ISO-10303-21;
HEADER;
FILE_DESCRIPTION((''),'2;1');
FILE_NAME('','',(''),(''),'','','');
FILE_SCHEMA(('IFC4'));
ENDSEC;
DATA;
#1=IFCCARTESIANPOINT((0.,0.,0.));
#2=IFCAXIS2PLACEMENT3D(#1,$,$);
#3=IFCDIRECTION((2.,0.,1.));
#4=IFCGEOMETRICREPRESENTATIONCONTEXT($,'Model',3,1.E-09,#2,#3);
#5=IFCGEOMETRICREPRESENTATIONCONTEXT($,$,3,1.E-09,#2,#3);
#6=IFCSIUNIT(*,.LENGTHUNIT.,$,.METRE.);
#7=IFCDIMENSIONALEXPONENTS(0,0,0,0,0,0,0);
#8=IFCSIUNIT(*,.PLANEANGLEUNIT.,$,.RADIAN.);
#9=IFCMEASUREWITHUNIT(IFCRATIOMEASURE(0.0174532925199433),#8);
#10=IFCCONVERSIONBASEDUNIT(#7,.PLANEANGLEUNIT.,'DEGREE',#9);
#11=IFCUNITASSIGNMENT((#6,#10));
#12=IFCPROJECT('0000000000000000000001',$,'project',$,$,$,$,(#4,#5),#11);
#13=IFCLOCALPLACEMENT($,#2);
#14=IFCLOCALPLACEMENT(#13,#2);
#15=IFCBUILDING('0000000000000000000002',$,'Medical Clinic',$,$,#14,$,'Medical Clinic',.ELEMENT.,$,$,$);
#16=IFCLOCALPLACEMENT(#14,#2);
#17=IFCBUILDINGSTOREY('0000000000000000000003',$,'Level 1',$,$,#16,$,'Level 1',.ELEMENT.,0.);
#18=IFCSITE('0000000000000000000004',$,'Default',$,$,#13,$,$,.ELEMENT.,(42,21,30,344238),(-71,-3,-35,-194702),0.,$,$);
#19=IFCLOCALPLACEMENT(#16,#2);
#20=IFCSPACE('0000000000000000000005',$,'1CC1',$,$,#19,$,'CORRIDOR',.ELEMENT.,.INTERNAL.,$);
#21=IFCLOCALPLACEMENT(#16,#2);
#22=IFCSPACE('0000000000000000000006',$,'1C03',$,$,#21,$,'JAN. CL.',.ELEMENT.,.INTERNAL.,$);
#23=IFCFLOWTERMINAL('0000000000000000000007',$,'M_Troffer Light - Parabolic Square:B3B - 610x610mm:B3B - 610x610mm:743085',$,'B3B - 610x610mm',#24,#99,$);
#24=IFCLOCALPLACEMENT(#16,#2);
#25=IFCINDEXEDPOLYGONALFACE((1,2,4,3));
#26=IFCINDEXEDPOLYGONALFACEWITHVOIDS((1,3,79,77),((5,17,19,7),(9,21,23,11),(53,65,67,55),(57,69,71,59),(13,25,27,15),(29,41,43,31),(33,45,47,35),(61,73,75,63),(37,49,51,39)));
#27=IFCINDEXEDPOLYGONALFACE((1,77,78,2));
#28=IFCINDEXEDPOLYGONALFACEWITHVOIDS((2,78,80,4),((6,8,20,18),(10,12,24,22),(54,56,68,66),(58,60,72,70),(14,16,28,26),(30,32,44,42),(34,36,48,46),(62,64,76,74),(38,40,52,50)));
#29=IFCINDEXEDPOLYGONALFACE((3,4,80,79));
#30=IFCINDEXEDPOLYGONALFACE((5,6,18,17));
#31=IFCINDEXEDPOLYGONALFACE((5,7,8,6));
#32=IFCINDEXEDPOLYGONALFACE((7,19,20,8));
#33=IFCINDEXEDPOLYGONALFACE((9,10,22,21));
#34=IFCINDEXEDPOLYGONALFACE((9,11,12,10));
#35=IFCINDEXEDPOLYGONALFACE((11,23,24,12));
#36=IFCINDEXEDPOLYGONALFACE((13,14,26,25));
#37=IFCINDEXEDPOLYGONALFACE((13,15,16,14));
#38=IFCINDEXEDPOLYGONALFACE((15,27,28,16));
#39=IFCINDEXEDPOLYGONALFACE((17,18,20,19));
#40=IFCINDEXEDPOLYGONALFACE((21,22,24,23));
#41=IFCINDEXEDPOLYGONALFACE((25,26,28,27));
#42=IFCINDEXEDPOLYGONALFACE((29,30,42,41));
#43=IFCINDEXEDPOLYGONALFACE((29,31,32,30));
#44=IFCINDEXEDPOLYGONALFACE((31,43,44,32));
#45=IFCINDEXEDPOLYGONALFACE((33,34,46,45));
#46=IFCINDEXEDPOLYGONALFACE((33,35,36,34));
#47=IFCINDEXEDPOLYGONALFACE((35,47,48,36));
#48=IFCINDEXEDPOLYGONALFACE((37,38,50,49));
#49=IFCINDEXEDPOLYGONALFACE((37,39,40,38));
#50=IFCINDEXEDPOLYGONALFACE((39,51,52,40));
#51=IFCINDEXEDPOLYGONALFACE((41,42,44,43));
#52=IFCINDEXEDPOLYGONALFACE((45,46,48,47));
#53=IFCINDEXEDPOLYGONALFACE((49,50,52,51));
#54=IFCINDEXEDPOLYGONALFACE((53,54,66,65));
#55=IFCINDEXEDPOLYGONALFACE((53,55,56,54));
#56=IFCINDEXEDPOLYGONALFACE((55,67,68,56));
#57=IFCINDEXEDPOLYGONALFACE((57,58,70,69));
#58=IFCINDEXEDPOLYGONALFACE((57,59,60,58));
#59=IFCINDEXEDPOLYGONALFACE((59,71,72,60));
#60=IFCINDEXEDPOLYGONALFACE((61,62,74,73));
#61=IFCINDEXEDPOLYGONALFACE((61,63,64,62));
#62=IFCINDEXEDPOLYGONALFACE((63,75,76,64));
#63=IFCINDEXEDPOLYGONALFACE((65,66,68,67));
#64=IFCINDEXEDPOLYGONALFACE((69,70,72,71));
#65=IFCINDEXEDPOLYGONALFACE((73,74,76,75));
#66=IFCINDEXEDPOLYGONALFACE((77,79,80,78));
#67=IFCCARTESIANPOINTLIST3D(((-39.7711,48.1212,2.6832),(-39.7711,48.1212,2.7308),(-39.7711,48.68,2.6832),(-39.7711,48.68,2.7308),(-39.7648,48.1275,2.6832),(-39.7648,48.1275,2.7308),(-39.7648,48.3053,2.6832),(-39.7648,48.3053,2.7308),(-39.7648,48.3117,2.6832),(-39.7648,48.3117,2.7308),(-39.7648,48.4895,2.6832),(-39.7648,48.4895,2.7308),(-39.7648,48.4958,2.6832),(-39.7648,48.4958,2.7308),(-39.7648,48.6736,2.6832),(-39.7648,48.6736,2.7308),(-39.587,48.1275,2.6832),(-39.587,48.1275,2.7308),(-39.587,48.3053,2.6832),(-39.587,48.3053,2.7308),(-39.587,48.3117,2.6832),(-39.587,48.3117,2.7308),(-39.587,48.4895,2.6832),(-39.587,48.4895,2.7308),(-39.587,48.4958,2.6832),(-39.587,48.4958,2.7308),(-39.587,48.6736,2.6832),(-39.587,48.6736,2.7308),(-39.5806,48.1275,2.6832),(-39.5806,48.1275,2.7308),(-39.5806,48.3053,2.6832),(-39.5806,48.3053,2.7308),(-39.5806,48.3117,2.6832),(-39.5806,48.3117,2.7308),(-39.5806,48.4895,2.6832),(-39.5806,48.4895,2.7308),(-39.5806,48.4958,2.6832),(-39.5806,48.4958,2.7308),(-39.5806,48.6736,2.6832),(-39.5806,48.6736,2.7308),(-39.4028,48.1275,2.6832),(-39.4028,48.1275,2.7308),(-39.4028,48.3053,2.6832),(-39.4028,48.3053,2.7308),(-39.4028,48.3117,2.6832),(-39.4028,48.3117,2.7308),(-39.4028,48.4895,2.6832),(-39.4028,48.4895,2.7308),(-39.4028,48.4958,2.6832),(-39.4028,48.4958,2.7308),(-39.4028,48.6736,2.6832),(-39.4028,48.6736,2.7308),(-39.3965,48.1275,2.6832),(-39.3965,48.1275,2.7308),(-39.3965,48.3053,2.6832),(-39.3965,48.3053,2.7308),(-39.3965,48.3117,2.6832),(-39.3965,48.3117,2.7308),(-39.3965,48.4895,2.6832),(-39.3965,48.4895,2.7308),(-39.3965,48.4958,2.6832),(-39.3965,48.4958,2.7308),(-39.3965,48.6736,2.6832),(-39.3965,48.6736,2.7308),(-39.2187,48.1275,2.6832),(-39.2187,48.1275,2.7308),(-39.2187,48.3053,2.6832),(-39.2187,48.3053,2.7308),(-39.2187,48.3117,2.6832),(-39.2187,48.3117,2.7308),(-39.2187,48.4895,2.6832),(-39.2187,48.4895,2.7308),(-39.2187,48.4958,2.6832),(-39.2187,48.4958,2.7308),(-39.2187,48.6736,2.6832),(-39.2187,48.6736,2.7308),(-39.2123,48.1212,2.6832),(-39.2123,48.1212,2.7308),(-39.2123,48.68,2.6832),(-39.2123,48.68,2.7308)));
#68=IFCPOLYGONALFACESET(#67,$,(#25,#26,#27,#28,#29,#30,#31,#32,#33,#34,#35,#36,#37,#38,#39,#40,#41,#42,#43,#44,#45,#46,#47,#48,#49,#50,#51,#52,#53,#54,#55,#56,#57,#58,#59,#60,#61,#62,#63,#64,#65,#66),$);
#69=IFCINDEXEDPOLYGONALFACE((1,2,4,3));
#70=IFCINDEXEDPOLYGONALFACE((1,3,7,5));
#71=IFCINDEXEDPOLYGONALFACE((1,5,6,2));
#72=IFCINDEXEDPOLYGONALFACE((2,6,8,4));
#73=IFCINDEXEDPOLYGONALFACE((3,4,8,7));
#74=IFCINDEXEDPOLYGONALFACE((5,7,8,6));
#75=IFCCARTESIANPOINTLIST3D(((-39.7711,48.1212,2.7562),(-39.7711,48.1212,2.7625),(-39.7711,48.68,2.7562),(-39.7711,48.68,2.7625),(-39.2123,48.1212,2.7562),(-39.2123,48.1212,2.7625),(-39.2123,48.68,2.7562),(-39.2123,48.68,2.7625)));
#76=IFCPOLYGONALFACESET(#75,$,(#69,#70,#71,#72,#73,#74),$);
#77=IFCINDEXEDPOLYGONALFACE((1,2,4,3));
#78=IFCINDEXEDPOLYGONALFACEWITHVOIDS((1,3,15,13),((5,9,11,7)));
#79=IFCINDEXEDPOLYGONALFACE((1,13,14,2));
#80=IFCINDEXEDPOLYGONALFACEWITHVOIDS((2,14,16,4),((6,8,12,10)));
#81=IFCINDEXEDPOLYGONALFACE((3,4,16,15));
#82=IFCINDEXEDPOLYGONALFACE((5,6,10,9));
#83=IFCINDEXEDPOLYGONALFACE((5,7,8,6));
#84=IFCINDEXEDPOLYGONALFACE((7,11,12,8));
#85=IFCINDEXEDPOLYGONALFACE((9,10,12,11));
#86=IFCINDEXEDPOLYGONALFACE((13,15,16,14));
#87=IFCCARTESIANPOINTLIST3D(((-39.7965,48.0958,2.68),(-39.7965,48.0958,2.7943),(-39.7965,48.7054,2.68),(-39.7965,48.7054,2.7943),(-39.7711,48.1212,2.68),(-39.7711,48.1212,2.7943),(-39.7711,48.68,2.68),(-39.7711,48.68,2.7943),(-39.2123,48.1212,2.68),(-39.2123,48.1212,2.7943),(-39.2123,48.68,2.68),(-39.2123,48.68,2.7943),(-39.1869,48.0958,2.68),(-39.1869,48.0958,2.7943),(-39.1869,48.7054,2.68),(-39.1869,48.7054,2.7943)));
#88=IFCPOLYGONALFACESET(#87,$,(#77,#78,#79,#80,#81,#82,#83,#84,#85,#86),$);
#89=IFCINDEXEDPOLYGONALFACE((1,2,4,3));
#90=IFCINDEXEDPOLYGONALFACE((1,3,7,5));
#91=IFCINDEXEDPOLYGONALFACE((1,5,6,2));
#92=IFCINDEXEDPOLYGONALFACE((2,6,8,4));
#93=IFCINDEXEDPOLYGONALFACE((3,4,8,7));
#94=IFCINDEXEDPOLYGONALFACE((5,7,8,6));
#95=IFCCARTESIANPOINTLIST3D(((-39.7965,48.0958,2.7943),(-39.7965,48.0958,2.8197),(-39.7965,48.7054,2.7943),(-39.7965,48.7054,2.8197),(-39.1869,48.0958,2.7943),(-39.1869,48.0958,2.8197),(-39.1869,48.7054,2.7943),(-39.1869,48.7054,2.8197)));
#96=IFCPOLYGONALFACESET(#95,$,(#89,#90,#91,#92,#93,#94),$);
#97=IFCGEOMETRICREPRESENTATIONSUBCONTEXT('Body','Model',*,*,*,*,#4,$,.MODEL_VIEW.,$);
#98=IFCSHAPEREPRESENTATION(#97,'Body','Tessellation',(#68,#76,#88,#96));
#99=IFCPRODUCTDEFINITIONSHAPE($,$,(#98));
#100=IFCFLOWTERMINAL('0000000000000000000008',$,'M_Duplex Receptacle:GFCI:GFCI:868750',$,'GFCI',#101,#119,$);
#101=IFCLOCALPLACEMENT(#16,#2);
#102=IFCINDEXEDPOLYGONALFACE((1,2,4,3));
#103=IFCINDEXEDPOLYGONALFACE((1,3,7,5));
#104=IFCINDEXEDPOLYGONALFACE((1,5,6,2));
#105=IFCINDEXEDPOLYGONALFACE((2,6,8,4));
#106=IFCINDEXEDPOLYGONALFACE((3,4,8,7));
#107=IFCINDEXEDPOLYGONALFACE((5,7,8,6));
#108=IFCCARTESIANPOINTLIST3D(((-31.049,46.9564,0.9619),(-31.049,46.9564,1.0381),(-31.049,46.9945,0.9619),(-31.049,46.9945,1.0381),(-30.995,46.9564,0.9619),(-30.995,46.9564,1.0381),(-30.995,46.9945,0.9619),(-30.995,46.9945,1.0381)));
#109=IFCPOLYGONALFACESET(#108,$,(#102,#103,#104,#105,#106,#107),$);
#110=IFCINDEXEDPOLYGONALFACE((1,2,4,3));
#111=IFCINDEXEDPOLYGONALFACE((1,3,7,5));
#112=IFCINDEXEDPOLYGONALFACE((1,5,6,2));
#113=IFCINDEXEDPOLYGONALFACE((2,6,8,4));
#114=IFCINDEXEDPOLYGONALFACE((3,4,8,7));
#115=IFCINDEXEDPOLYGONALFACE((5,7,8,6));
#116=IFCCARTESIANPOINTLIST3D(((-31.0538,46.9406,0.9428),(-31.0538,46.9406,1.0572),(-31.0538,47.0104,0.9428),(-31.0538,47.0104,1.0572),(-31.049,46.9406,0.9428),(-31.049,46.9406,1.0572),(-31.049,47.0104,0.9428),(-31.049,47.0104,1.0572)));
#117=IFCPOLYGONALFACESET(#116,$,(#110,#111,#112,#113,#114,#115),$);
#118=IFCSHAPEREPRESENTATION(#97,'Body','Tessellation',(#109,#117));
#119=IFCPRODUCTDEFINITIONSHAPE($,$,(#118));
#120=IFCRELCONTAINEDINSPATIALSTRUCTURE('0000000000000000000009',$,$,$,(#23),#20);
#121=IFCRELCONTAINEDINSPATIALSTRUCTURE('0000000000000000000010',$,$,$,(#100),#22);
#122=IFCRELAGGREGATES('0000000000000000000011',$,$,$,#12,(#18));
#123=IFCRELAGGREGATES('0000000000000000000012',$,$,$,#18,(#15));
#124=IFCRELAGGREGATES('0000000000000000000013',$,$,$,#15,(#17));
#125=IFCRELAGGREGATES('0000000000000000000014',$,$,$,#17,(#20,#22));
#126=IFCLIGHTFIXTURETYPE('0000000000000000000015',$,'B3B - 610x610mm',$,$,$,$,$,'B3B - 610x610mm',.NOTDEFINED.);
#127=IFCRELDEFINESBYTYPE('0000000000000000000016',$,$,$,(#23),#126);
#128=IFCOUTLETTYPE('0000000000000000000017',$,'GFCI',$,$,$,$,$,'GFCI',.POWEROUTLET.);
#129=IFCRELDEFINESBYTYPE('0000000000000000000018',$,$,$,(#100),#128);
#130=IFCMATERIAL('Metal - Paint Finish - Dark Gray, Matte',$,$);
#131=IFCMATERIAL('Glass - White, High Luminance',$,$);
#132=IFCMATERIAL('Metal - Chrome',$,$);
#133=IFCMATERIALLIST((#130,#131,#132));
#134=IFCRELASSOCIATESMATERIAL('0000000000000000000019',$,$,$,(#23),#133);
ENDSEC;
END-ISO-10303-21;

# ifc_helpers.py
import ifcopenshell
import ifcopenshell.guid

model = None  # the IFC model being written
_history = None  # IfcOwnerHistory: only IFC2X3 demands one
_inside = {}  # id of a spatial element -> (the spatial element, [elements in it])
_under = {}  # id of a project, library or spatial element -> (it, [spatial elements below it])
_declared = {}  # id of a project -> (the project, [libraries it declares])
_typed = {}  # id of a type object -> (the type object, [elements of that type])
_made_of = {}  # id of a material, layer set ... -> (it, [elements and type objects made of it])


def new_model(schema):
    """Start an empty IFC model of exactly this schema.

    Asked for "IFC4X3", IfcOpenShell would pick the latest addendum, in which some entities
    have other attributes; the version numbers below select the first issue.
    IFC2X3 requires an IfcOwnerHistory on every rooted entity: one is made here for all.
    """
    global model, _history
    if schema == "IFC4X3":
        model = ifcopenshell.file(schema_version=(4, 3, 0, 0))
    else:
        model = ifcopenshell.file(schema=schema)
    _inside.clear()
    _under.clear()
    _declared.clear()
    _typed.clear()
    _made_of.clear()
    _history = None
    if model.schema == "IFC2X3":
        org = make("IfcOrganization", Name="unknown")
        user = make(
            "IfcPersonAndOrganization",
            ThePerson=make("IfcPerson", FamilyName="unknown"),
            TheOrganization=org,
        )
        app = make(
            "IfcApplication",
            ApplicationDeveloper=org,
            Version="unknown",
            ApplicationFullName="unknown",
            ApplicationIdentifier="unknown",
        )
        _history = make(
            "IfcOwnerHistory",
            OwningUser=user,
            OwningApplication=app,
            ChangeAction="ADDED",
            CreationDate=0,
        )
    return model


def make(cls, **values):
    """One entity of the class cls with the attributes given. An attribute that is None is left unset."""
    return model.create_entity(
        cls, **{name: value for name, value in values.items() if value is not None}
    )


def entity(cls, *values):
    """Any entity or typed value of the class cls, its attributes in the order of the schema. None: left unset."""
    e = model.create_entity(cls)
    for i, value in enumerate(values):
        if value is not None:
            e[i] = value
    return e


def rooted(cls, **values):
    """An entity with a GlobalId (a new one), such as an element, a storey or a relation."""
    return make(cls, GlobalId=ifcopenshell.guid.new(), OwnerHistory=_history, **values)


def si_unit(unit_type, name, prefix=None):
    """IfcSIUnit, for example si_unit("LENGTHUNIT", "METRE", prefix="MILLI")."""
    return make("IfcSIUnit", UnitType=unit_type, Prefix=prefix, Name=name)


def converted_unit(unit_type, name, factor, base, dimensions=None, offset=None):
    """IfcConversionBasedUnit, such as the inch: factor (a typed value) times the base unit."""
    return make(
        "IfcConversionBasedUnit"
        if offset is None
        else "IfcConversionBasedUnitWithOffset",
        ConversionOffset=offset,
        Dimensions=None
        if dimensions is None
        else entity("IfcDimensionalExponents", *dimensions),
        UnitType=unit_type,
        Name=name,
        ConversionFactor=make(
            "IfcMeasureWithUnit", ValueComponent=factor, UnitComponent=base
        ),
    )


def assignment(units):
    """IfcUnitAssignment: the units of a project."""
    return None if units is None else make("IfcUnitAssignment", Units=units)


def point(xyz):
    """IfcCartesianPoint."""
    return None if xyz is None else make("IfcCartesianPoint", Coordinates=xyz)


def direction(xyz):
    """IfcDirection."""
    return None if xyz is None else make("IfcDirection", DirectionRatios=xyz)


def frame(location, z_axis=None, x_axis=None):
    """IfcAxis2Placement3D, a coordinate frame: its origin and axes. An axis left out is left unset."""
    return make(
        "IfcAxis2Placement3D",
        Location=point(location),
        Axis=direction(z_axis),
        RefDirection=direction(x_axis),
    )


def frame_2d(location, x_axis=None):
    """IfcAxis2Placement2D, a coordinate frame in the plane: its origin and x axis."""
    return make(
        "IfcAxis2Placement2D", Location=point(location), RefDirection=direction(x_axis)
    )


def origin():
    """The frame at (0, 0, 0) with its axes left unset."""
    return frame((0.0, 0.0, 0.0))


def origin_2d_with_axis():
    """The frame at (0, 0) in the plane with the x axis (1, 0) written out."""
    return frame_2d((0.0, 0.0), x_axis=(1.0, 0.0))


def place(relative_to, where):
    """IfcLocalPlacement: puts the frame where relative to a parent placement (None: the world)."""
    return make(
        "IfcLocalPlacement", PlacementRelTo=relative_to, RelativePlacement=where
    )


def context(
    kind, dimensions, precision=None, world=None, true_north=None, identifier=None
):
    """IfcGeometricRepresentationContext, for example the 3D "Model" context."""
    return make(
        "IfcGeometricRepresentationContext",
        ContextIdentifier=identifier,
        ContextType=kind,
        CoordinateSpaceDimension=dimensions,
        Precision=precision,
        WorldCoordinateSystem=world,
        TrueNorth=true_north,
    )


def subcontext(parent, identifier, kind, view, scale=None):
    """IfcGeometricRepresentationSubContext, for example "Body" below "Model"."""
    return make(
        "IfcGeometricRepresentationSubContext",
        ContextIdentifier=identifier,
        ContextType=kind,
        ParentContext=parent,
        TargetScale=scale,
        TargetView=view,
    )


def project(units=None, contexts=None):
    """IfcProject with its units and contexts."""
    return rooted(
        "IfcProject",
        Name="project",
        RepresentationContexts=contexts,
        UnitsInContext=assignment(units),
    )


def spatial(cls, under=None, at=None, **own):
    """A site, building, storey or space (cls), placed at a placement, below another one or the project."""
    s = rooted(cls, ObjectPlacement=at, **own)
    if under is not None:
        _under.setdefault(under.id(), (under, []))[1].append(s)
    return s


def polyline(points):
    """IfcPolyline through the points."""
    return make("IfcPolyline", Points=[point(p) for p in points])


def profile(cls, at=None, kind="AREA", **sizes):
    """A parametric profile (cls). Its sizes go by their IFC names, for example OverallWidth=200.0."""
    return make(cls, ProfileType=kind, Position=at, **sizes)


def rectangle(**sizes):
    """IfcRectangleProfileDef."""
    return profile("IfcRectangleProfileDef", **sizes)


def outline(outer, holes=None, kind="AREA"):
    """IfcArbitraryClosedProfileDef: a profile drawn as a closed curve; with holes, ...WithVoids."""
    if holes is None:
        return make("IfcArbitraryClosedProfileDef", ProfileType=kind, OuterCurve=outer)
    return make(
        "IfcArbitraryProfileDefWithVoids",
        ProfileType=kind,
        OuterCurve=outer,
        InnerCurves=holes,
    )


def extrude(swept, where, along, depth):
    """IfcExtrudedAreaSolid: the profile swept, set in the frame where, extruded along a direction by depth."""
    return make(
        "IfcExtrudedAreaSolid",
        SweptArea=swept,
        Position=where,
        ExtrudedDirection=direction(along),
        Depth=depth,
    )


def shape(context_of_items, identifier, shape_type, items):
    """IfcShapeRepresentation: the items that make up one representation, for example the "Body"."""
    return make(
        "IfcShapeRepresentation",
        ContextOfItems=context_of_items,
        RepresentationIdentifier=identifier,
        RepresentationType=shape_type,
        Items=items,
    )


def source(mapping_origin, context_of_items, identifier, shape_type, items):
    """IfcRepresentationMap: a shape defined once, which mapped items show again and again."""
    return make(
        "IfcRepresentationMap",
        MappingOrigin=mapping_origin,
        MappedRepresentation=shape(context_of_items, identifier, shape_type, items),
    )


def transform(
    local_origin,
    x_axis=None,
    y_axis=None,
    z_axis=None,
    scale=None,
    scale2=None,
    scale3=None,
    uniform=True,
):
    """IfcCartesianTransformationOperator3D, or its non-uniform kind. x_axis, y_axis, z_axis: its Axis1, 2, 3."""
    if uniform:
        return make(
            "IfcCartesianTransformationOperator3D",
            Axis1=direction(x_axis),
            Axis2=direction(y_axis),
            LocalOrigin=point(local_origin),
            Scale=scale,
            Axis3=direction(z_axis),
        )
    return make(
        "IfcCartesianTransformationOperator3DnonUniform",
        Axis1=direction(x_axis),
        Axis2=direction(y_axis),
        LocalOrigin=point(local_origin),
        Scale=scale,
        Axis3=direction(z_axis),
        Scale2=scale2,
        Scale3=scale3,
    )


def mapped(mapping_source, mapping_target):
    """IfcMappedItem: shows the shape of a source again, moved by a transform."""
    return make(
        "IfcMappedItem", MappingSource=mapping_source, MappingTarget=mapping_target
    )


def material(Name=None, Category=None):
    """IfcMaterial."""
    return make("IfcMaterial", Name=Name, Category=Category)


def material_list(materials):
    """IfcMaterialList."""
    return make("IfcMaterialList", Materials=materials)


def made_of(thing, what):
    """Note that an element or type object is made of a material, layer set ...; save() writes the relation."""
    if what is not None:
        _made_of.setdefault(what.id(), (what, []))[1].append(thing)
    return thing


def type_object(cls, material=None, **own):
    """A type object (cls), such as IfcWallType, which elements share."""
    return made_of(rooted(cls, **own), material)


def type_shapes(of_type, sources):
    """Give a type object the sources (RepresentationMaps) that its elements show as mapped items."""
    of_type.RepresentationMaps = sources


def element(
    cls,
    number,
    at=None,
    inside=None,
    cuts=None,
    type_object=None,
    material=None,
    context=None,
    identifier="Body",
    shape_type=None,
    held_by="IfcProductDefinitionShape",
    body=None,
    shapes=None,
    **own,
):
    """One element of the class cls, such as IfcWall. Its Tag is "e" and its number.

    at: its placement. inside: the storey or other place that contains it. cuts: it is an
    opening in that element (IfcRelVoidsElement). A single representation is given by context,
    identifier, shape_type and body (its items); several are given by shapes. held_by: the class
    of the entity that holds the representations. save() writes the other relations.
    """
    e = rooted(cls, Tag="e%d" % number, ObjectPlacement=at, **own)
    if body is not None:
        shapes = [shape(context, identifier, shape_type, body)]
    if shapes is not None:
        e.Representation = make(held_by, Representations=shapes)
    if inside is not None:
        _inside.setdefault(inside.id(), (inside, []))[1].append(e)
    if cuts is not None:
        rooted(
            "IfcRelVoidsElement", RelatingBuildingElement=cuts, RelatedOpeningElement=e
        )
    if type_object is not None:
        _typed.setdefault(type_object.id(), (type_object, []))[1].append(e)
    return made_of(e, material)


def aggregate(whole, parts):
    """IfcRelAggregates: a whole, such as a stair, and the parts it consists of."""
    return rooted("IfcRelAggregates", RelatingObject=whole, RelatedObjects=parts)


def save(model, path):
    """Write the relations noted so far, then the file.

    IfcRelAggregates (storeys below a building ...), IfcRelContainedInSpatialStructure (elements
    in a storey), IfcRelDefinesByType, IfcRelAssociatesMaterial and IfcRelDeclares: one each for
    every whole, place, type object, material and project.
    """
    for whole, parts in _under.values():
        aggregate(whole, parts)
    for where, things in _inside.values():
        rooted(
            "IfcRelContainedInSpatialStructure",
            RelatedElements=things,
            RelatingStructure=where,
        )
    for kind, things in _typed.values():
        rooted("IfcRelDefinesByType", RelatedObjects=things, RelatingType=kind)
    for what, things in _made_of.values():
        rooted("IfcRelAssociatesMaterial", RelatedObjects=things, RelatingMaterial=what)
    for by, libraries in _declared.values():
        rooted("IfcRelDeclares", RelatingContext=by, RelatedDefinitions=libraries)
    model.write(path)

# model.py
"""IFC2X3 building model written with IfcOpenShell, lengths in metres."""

from ifc_helpers import new_model, entity, si_unit, converted_unit, direction, frame, frame_2d, origin, origin_2d_with_axis, place, context, subcontext, project, spatial, polyline, rectangle, outline, extrude, source, transform, mapped, material, material_list, type_object, type_shapes, element, save


model = new_model("IFC2X3")

# Units and contexts
model_context = context("Model", 3, precision=1e-09, world=origin(), true_north=direction((2.0, 0.0, 1.0)))
context_of_model = context(None, 3, precision=1e-09, world=origin(), true_north=direction((2.0, 0.0, 1.0)))
body_context = subcontext(model_context, "Body", "Model", "MODEL_VIEW")
ifc_project = project(units=[si_unit("LENGTHUNIT", "METRE"), converted_unit("PLANEANGLEUNIT", "DEGREE", entity("IfcRatioMeasure", 0.0174532925199433), si_unit("PLANEANGLEUNIT", "RADIAN"), dimensions=[0, 0, 0, 0, 0, 0, 0])], contexts=[model_context, context_of_model])

# Site, building, storey
site_placement = place(None, origin())
site = spatial("IfcSite", under=ifc_project, at=site_placement, Name="Default", CompositionType="ELEMENT", RefLatitude=(42, 21, 30, 344238), RefLongitude=(-71, -3, -35, -194702), RefElevation=0.0)
building_placement = place(site_placement, origin())
building = spatial("IfcBuilding", under=site, at=building_placement, Name="Medical Clinic", LongName="Medical Clinic", CompositionType="ELEMENT")
storey_placement = place(building_placement, origin())
storey = spatial("IfcBuildingStorey", under=building, at=storey_placement, Name="Level 1", LongName="Level 1", CompositionType="ELEMENT", Elevation=0.0)

# Shared definitions
space_1_placement = place(storey_placement, origin())
space_1 = spatial("IfcSpace", under=storey, at=space_1_placement, Name="1CC1", LongName="CORRIDOR", CompositionType="ELEMENT", InteriorOrExteriorSpace="INTERNAL")

# Shared definitions
space_2_placement = place(storey_placement, origin())
space_2 = spatial("IfcSpace", under=storey, at=space_2_placement, Name="1C03", LongName="JAN. CL.", CompositionType="ELEMENT", InteriorOrExteriorSpace="INTERNAL")

# Flow terminals
ifc_material_1 = material(Name="Metal - Paint Finish - Dark Gray, Matte")
ifc_material_2 = material(Name="Glass - White, High Luminance")
ifc_material_3 = material(Name="Metal - Chrome")
ifc_material_list_1 = material_list([ifc_material_1, ifc_material_2, ifc_material_3])
light_fixture_type_1 = type_object("IfcLightFixtureType", Name="B3B - 610x610mm", ElementType="B3B - 610x610mm", PredefinedType="NOTDEFINED")
shared_shape_1 = source(origin(), body_context, "Body", "SweptSolid", [
    extrude(outline(polyline([(-0.2794, -0.2794), (0.2794, -0.2794), (0.2794, 0.2794), (-0.2794, 0.2794), (-0.2794, -0.2794)]), holes=[polyline([(-0.0952, 0.0953), (-0.273, 0.0953), (-0.273, 0.2731), (-0.0952, 0.2731), (-0.0952, 0.0953)]), polyline([(0.2731, 0.0953), (0.0953, 0.0953), (0.0953, 0.2731), (0.2731, 0.2731), (0.2731, 0.0953)]), polyline([(-0.0889, 0.2731), (0.0889, 0.2731), (0.0889, 0.0953), (-0.0889, 0.0953), (-0.0889, 0.2731)]), polyline([(0.2731, -0.273), (0.0953, -0.273), (0.0953, -0.0952), (0.2731, -0.0952), (0.2731, -0.273)]), polyline([(0.0889, -0.273), (-0.0889, -0.273), (-0.0889, -0.0952), (0.0889, -0.0952), (0.0889, -0.273)]), polyline([(-0.0952, -0.273), (-0.273, -0.273), (-0.273, -0.0952), (-0.0952, -0.0952), (-0.0952, -0.273)]), polyline([(-0.0952, -0.0889), (-0.273, -0.0889), (-0.273, 0.0889), (-0.0952, 0.0889), (-0.0952, -0.0889)]), polyline([(0.0889, -0.0889), (-0.0889, -0.0889), (-0.0889, 0.0889), (0.0889, 0.0889), (0.0889, -0.0889)]), polyline([(0.2731, -0.0889), (0.0953, -0.0889), (0.0953, 0.0889), (0.2731, 0.0889), (0.2731, -0.0889)])]), frame((0.0, -0.3048, -0.0508), z_axis=(0.0, 0.0, 1.0), x_axis=(-1.0, 0.0, 0.0)), (0.0, 0.0, 1.0), 0.0476),
    extrude(rectangle(XDim=0.5588, YDim=0.5588, at=origin_2d_with_axis()), frame((0.0, -0.3048, -0.0825), z_axis=(0.0, 0.0, 1.0), x_axis=(-1.0, 0.0, 0.0)), (0.0, 0.0, 1.0), 0.0064),
    extrude(outline(polyline([(-0.3048, -0.3048), (0.3048, -0.3048), (0.3048, 0.3048), (-0.3048, 0.3048), (-0.3048, -0.3048)]), holes=[polyline([(0.2794, 0.2794), (0.2794, -0.2794), (-0.2794, -0.2794), (-0.2794, 0.2794), (0.2794, 0.2794)])]), frame((0.0, -0.3048, -0.1143)), (0.0, 0.0, 1.0), 0.1143),
    extrude(rectangle(XDim=0.6096, YDim=0.6096, at=origin_2d_with_axis()), frame((0.0, -0.3048, -0.1397), z_axis=(0.0, 0.0, 1.0), x_axis=(-1.0, 0.0, 0.0)), (0.0, 0.0, 1.0), 0.0254),
])
type_shapes(light_fixture_type_1, [shared_shape_1])
flow_terminal_1_placement = place(space_1_placement, frame((-39.4917, 48.0958, 2.68), z_axis=(0.0, 0.0, -1.0), x_axis=(1.0, 0.0, 0.0)))
element("IfcFlowTerminal", 1, at=flow_terminal_1_placement, inside=space_1, type_object=light_fixture_type_1, material=ifc_material_list_1, Name="M_Troffer Light - Parabolic Square:B3B - 610x610mm:B3B - 610x610mm:743085", ObjectType="B3B - 610x610mm", context=body_context, shape_type="MappedRepresentation", body=[
    mapped(shared_shape_1, transform((0.0, 0.0, 0.0), scale=1.0)),
])
outlet_type_1 = type_object("IfcOutletType", Name="GFCI", ElementType="GFCI", PredefinedType="POWEROUTLET")
shared_shape_2 = source(origin(), body_context, "Body", "SweptSolid", [
    extrude(rectangle(XDim=0.0381, YDim=0.0762, at=origin_2d_with_axis()), frame((0.0, 0.0, -0.054), z_axis=(0.0, 0.0, 1.0), x_axis=(-1.0, 0.0, 0.0)), (0.0, 0.0, 1.0), 0.054),
    extrude(rectangle(XDim=0.0698, YDim=0.1143, at=frame_2d((0.0, 0.0), x_axis=(1.0, 0.0))), frame((0.0, 0.0, 0.0), z_axis=(0.0, 0.0, 1.0), x_axis=(-1.0, 0.0, 0.0)), (0.0, 0.0, 1.0), 0.0048),
])
type_shapes(outlet_type_1, [shared_shape_2])
flow_terminal_2_placement = place(space_2_placement, frame((-31.049, 46.9755, 1.0), z_axis=(-1.0, 0.0, 0.0), x_axis=(0.0, -1.0, 0.0)))
element("IfcFlowTerminal", 2, at=flow_terminal_2_placement, inside=space_2, type_object=outlet_type_1, Name="M_Duplex Receptacle:GFCI:GFCI:868750", ObjectType="GFCI", context=body_context, shape_type="MappedRepresentation", body=[
    mapped(shared_shape_2, transform((0.0, 0.0, 0.0), scale=1.0)),
])

save(model, "model.ifc")
